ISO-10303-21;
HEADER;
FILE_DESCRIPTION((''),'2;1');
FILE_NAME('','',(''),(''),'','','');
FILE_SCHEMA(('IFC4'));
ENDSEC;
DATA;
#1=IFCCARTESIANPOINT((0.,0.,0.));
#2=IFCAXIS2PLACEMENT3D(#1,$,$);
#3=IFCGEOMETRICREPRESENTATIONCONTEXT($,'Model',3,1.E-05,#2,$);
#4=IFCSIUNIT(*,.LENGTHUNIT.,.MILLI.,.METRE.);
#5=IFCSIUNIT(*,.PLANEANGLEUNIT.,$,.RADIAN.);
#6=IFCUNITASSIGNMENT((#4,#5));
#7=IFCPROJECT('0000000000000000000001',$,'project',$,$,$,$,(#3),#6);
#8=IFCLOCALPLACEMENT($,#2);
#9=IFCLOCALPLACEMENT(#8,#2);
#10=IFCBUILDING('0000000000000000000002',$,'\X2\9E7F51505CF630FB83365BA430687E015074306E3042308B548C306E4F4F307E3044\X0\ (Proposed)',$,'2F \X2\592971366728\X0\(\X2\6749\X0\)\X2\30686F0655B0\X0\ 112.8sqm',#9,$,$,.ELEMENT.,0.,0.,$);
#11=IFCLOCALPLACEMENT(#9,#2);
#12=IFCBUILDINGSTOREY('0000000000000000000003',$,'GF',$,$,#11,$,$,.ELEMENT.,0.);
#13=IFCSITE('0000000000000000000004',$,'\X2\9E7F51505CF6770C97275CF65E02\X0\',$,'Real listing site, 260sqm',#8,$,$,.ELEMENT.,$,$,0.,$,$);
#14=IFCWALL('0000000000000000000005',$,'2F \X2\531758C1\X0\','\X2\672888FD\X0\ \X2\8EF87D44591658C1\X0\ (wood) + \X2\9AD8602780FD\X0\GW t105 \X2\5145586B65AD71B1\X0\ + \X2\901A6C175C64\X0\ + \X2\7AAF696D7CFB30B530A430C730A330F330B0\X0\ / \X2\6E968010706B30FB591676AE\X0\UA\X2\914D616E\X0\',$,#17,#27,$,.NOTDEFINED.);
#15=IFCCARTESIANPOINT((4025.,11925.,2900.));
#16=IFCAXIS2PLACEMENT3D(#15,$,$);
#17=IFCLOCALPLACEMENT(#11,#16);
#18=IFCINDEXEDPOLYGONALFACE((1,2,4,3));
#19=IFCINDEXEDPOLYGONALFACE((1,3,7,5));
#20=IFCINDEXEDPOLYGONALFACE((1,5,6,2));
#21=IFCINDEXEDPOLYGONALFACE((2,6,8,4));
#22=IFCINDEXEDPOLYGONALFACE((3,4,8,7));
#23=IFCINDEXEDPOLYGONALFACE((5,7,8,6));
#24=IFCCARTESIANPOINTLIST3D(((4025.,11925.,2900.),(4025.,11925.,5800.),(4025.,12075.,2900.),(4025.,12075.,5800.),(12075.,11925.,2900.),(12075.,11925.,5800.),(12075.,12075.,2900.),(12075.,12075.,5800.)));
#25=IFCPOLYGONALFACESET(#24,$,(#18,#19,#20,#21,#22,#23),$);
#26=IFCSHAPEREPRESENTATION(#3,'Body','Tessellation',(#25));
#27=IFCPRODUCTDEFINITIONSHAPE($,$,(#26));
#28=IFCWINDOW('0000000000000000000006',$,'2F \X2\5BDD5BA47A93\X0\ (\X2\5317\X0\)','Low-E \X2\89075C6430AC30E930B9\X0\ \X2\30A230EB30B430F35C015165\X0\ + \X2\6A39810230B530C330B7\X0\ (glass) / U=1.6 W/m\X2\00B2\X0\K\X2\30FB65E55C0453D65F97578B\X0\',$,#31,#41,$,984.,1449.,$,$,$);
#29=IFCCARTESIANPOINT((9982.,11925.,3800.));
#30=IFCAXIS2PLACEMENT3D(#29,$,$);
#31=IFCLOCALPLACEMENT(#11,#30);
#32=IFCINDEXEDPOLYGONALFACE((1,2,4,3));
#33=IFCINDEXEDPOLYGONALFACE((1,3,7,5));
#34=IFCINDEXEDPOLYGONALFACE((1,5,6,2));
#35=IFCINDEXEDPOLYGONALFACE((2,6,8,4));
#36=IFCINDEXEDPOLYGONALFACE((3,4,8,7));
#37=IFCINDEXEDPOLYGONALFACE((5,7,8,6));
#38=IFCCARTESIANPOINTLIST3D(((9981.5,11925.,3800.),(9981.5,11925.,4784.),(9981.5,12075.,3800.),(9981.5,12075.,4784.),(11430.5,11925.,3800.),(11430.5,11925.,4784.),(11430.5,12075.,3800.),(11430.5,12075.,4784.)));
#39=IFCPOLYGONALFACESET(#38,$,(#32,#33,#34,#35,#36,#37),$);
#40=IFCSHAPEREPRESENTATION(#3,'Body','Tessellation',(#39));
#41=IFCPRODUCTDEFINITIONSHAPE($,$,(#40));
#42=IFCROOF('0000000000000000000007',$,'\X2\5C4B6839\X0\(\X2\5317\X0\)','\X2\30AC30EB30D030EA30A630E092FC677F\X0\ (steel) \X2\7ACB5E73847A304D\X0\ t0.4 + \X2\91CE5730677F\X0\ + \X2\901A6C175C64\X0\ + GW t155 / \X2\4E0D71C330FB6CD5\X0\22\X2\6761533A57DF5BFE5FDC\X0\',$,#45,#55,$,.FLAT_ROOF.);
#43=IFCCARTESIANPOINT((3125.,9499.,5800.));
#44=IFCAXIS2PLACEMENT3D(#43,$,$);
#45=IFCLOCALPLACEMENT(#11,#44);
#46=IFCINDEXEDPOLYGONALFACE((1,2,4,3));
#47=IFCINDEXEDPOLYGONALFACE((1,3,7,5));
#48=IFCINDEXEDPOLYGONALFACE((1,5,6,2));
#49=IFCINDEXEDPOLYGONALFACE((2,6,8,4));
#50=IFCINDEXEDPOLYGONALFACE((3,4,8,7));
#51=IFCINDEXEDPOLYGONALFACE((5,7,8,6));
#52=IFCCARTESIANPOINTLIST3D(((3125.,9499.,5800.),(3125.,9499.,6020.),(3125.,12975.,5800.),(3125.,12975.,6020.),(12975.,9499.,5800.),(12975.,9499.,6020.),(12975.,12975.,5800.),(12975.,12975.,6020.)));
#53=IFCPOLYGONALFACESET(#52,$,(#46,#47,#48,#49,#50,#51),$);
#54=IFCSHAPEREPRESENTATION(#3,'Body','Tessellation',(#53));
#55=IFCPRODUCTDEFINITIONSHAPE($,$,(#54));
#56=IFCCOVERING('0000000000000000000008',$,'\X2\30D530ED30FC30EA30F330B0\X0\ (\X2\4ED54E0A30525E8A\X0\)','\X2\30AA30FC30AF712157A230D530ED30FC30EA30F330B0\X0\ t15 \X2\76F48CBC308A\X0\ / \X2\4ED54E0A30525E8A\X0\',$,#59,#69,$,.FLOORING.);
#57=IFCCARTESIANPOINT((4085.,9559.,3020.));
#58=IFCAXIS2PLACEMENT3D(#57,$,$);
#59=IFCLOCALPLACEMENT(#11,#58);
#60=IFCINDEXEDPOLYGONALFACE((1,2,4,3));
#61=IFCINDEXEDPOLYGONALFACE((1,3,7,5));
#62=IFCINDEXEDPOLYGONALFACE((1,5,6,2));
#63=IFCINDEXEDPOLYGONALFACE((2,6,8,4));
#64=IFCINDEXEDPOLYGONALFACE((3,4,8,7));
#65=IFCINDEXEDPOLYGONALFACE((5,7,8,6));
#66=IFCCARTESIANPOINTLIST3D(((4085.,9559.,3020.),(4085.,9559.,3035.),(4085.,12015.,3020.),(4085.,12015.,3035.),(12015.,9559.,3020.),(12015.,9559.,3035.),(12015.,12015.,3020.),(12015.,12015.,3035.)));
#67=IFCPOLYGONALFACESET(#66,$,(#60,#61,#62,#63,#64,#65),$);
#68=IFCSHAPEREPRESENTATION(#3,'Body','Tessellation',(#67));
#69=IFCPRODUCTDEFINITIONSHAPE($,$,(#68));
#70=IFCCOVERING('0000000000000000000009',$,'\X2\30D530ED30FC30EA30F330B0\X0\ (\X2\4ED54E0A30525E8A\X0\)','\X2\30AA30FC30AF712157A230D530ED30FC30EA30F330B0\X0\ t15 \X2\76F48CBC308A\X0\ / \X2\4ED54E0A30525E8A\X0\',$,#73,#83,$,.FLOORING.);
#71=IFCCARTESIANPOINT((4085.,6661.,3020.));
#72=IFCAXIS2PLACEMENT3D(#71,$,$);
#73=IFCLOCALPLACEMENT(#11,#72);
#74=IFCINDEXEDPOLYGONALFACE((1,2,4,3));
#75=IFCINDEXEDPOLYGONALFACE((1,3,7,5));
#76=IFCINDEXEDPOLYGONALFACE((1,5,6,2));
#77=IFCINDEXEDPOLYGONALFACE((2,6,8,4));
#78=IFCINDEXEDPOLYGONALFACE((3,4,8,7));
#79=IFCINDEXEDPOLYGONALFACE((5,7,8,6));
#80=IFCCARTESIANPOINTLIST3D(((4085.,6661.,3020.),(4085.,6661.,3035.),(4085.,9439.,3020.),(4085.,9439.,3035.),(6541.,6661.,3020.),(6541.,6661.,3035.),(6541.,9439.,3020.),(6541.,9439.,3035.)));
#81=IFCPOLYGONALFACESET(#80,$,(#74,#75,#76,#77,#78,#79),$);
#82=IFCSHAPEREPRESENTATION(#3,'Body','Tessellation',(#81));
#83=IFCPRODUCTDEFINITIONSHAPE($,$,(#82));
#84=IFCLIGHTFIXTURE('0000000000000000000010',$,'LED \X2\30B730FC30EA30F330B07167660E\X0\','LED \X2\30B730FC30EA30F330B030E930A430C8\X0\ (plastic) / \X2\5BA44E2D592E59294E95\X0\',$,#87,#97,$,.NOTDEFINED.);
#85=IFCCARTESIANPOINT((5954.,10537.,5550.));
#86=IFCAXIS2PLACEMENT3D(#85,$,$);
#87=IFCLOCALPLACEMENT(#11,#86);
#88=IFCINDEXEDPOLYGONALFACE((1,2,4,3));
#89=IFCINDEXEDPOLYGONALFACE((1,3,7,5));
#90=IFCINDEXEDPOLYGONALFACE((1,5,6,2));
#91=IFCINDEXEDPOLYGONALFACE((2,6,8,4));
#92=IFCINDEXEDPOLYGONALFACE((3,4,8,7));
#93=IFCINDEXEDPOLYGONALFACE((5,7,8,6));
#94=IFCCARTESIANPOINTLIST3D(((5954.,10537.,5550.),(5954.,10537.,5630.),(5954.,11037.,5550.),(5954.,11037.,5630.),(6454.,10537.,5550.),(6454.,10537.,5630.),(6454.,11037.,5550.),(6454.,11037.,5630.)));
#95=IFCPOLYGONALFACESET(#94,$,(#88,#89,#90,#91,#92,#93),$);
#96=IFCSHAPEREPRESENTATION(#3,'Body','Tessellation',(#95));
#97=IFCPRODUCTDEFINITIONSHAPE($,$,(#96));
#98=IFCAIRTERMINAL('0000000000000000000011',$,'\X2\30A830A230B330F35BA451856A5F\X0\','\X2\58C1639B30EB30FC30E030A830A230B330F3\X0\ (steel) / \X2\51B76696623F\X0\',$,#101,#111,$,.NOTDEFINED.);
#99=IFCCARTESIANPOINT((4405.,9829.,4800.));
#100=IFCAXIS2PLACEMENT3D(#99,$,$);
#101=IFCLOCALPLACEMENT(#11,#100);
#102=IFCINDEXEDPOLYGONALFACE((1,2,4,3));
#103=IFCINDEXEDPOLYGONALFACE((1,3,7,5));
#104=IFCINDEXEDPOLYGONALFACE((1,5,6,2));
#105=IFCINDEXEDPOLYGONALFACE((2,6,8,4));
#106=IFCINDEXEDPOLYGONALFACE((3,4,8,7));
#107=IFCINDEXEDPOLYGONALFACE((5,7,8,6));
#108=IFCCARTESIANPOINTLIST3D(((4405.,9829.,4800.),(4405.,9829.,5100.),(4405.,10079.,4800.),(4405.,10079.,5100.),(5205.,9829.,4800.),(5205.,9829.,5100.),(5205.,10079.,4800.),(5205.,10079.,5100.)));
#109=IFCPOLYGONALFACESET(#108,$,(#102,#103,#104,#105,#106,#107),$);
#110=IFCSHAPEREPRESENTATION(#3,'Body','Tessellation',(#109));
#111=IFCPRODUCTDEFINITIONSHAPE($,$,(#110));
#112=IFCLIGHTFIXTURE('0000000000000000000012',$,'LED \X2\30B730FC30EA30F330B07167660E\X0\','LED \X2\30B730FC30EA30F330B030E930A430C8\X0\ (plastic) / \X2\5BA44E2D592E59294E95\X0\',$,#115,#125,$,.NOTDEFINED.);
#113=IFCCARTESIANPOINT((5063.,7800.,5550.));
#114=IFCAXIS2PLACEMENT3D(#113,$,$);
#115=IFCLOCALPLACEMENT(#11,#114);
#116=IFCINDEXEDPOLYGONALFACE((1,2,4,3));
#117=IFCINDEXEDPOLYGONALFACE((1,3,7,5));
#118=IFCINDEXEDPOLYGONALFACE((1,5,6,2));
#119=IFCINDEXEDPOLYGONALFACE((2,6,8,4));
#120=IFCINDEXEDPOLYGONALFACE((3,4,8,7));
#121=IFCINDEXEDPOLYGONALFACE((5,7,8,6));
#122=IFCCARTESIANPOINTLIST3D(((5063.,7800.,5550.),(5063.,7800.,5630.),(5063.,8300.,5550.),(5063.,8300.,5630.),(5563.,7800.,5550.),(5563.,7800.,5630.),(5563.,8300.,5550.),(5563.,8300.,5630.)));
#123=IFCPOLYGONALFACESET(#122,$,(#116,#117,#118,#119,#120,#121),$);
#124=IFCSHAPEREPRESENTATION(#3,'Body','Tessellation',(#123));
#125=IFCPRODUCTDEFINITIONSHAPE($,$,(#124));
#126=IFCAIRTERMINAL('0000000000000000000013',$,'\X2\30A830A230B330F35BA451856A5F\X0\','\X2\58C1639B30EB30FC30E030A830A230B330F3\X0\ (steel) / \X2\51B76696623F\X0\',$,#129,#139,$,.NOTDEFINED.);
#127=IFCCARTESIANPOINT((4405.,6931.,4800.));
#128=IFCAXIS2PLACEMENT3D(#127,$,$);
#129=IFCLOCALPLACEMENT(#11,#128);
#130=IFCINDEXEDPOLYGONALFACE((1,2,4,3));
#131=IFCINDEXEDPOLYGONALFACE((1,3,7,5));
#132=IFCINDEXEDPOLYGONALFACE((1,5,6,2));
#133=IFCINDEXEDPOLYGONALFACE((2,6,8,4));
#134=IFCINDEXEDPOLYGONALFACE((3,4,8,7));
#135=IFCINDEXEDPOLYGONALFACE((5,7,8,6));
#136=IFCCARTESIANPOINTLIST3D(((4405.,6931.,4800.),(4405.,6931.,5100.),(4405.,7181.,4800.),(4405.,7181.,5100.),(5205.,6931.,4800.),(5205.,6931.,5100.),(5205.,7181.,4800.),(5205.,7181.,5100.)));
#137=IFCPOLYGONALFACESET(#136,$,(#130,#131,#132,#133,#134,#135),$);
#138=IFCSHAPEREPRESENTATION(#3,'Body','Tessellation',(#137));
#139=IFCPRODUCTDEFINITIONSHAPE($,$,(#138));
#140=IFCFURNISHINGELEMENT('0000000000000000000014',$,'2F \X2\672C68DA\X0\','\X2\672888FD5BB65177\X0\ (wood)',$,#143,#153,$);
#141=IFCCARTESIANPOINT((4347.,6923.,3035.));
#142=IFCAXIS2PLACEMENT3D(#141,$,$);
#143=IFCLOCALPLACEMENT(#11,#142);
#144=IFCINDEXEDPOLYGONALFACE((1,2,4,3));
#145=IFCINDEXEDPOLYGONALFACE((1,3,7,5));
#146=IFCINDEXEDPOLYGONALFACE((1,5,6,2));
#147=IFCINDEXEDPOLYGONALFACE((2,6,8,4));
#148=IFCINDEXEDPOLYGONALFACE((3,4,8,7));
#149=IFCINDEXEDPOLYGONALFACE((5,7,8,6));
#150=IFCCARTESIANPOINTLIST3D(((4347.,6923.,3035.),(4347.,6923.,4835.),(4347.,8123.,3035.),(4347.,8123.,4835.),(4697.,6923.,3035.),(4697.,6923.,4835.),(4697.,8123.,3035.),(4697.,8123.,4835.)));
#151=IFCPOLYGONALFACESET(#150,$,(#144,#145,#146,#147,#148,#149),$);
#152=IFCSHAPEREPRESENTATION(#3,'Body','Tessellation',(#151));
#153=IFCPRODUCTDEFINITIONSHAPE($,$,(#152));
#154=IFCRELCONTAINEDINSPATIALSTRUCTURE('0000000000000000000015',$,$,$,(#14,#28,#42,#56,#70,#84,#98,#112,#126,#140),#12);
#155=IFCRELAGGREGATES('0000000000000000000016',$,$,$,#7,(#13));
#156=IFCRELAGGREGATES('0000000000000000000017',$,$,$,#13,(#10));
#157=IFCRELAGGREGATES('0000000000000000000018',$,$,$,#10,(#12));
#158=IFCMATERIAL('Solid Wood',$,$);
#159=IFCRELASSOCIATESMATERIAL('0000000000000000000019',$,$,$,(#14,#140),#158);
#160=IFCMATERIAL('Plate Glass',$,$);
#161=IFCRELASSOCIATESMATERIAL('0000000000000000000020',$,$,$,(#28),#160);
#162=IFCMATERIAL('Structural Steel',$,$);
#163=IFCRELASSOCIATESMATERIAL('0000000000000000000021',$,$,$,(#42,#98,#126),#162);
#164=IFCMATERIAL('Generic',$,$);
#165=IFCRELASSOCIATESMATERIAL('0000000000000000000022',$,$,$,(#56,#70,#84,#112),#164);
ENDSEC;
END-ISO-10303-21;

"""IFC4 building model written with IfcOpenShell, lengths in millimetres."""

from ifc_helpers import new_model, si_unit, frame, frame_2d, origin, place, context, project, spatial, rectangle, extrude, material, element, fill, save


model = new_model("IFC4")

# Units and contexts
model_context = context("Model", 3, precision=1e-05, world=origin())
ifc_project = project(units=[si_unit("LENGTHUNIT", "METRE", prefix="MILLI"), si_unit("PLANEANGLEUNIT", "RADIAN")], contexts=[model_context])

# Site, building, storey
site_placement = place(None, origin())
site = spatial("IfcSite", under=ifc_project, at=site_placement, Name="鹿児島県霧島市", ObjectType="Real listing site, 260sqm", CompositionType="ELEMENT", RefElevation=0.0)
building_placement = place(site_placement, origin())
building = spatial("IfcBuilding", under=site, at=building_placement, Name="鹿児島・茶室と縁側のある和の住まい (Proposed)", ObjectType="2F 天然木(杉)と漆喰 112.8sqm", CompositionType="ELEMENT", ElevationOfRefHeight=0.0, ElevationOfTerrain=0.0)
storey_placement = place(building_placement, origin())
storey = spatial("IfcBuildingStorey", under=building, at=storey_placement, Name="GF", CompositionType="ELEMENT", Elevation=0.0)

# Shared definitions
ifc_material_1 = material(Name="Solid Wood")

# Wall, opening, window
wall_placement = place(storey_placement, frame((4025.0, 11925.0, 2900.0)))
wall = element("IfcWall", 1, at=wall_placement, inside=storey, material=ifc_material_1, Name="2F 北壁", Description="木製 軸組外壁 (wood) + 高性能GW t105 充填断熱 + 通気層 + 窯業系サイディング / 準耐火・外皮UA配慮", PredefinedType="NOTDEFINED", context=model_context, shape_type="SweptSolid", body=[
    extrude(rectangle(XDim=8050.0, YDim=150.0, at=frame_2d((4025.0, 75.0))), frame((4025.0, 11925.0, 2900.0)), (0.0, 0.0, 1.0), 2900.0),
])
opening_placement = place(storey_placement, frame((9982.0, 11925.0, 3800.0)))
opening = element("IfcOpeningElement", 2, at=opening_placement, cuts=wall, PredefinedType="NOTDEFINED", context=model_context, shape_type="SweptSolid", body=[
    extrude(rectangle(XDim=1449.0, YDim=150.0, at=frame_2d((724.0, 75.0))), frame((9982.0, 11925.0, 3800.0)), (0.0, 0.0, 1.0), 984.0),
])
ifc_material_2 = material(Name="Plate Glass")
window_placement = place(storey_placement, frame((9982.0, 11925.0, 3800.0)))
window = element("IfcWindow", 3, at=window_placement, inside=storey, material=ifc_material_2, Name="2F 寝室窓 (北)", Description="Low-E 複層ガラス アルゴン封入 + 樹脂サッシ (glass) / U=1.6 W/m²K・日射取得型", OverallHeight=984.0, OverallWidth=1449.0, context=model_context, shape_type="SweptSolid", body=[
    extrude(rectangle(XDim=1449.0, YDim=150.0, at=frame_2d((724.0, 75.0))), frame((9982.0, 11925.0, 3800.0)), (0.0, 0.0, 1.0), 984.0),
])
fill(opening, window)

# Roof
ifc_material_3 = material(Name="Structural Steel")
for number, where, name in (
    (4, (3125.0, 9499.0, 5800.0), "屋根(北)"),
):
    element("IfcRoof", number, at=place(storey_placement, frame(where)), inside=storey, material=ifc_material_3, Name=name, Description="ガルバリウム鋼板 (steel) 立平葺き t0.4 + 野地板 + 通気層 + GW t155 / 不燃・法22条区域対応", PredefinedType="FLAT_ROOF", context=model_context, shape_type="SweptSolid", body=[
        extrude(rectangle(XDim=9850.0, YDim=3476.0, at=frame_2d((4925.0, 1738.0))), frame((3125.0, 9499.0, 5800.0)), (0.0, 0.0, 1.0), 220.0),
    ])

# Coverings
ifc_material_4 = material(Name="Generic")
covering_1_placement = place(storey_placement, frame((4085.0, 9559.0, 3020.0)))
element("IfcCovering", 5, at=covering_1_placement, inside=storey, material=ifc_material_4, Name="フローリング (仕上げ床)", Description="オーク無垢フローリング t15 直貼り / 仕上げ床", PredefinedType="FLOORING", context=model_context, shape_type="SweptSolid", body=[
    extrude(rectangle(XDim=7930.0, YDim=2456.0, at=frame_2d((3965.0, 1228.0))), frame((4085.0, 9559.0, 3020.0)), (0.0, 0.0, 1.0), 15.0),
])
covering_2_placement = place(storey_placement, frame((4085.0, 6661.0, 3020.0)))
element("IfcCovering", 6, at=covering_2_placement, inside=storey, material=ifc_material_4, Name="フローリング (仕上げ床)", Description="オーク無垢フローリング t15 直貼り / 仕上げ床", PredefinedType="FLOORING", context=model_context, shape_type="SweptSolid", body=[
    extrude(rectangle(XDim=2456.0, YDim=2778.0, at=frame_2d((1228.0, 1389.0))), frame((4085.0, 6661.0, 3020.0)), (0.0, 0.0, 1.0), 15.0),
])

# Light fixture
light_fixture_1_placement = place(storey_placement, frame((5954.0, 10537.0, 5550.0)))
element("IfcLightFixture", 7, at=light_fixture_1_placement, inside=storey, material=ifc_material_4, Name="LED シーリング照明", Description="LED シーリングライト (plastic) / 室中央天井", PredefinedType="NOTDEFINED", context=model_context, shape_type="SweptSolid", body=[
    extrude(rectangle(XDim=500.0, YDim=500.0, at=frame_2d((250.0, 250.0))), frame((5954.0, 10537.0, 5550.0)), (0.0, 0.0, 1.0), 80.0),
])

# Air terminal
air_terminal_1_placement = place(storey_placement, frame((4405.0, 9829.0, 4800.0)))
element("IfcAirTerminal", 8, at=air_terminal_1_placement, inside=storey, material=ifc_material_3, Name="エアコン室内機", Description="壁掛ルームエアコン (steel) / 冷暖房", PredefinedType="NOTDEFINED", context=model_context, shape_type="SweptSolid", body=[
    extrude(rectangle(XDim=800.0, YDim=250.0, at=frame_2d((400.0, 125.0))), frame((4405.0, 9829.0, 4800.0)), (0.0, 0.0, 1.0), 300.0),
])

# Light fixture
light_fixture_2_placement = place(storey_placement, frame((5063.0, 7800.0, 5550.0)))
element("IfcLightFixture", 9, at=light_fixture_2_placement, inside=storey, material=ifc_material_4, Name="LED シーリング照明", Description="LED シーリングライト (plastic) / 室中央天井", PredefinedType="NOTDEFINED", context=model_context, shape_type="SweptSolid", body=[
    extrude(rectangle(XDim=500.0, YDim=500.0, at=frame_2d((250.0, 250.0))), frame((5063.0, 7800.0, 5550.0)), (0.0, 0.0, 1.0), 80.0),
])

# Air terminal
air_terminal_2_placement = place(storey_placement, frame((4405.0, 6931.0, 4800.0)))
element("IfcAirTerminal", 10, at=air_terminal_2_placement, inside=storey, material=ifc_material_3, Name="エアコン室内機", Description="壁掛ルームエアコン (steel) / 冷暖房", PredefinedType="NOTDEFINED", context=model_context, shape_type="SweptSolid", body=[
    extrude(rectangle(XDim=800.0, YDim=250.0, at=frame_2d((400.0, 125.0))), frame((4405.0, 6931.0, 4800.0)), (0.0, 0.0, 1.0), 300.0),
])

# Furnishing element
furnishing_placement = place(storey_placement, frame((4347.0, 6923.0, 3035.0)))
element("IfcFurnishingElement", 11, at=furnishing_placement, inside=storey, material=ifc_material_1, Name="2F 本棚", Description="木製家具 (wood)", context=model_context, shape_type="SweptSolid", body=[
    extrude(rectangle(XDim=350.0, YDim=1200.0, at=frame_2d((175.0, 600.0))), frame((4347.0, 6923.0, 3035.0)), (0.0, 0.0, 1.0), 1800.0),
])

save(model, "model.ifc")
